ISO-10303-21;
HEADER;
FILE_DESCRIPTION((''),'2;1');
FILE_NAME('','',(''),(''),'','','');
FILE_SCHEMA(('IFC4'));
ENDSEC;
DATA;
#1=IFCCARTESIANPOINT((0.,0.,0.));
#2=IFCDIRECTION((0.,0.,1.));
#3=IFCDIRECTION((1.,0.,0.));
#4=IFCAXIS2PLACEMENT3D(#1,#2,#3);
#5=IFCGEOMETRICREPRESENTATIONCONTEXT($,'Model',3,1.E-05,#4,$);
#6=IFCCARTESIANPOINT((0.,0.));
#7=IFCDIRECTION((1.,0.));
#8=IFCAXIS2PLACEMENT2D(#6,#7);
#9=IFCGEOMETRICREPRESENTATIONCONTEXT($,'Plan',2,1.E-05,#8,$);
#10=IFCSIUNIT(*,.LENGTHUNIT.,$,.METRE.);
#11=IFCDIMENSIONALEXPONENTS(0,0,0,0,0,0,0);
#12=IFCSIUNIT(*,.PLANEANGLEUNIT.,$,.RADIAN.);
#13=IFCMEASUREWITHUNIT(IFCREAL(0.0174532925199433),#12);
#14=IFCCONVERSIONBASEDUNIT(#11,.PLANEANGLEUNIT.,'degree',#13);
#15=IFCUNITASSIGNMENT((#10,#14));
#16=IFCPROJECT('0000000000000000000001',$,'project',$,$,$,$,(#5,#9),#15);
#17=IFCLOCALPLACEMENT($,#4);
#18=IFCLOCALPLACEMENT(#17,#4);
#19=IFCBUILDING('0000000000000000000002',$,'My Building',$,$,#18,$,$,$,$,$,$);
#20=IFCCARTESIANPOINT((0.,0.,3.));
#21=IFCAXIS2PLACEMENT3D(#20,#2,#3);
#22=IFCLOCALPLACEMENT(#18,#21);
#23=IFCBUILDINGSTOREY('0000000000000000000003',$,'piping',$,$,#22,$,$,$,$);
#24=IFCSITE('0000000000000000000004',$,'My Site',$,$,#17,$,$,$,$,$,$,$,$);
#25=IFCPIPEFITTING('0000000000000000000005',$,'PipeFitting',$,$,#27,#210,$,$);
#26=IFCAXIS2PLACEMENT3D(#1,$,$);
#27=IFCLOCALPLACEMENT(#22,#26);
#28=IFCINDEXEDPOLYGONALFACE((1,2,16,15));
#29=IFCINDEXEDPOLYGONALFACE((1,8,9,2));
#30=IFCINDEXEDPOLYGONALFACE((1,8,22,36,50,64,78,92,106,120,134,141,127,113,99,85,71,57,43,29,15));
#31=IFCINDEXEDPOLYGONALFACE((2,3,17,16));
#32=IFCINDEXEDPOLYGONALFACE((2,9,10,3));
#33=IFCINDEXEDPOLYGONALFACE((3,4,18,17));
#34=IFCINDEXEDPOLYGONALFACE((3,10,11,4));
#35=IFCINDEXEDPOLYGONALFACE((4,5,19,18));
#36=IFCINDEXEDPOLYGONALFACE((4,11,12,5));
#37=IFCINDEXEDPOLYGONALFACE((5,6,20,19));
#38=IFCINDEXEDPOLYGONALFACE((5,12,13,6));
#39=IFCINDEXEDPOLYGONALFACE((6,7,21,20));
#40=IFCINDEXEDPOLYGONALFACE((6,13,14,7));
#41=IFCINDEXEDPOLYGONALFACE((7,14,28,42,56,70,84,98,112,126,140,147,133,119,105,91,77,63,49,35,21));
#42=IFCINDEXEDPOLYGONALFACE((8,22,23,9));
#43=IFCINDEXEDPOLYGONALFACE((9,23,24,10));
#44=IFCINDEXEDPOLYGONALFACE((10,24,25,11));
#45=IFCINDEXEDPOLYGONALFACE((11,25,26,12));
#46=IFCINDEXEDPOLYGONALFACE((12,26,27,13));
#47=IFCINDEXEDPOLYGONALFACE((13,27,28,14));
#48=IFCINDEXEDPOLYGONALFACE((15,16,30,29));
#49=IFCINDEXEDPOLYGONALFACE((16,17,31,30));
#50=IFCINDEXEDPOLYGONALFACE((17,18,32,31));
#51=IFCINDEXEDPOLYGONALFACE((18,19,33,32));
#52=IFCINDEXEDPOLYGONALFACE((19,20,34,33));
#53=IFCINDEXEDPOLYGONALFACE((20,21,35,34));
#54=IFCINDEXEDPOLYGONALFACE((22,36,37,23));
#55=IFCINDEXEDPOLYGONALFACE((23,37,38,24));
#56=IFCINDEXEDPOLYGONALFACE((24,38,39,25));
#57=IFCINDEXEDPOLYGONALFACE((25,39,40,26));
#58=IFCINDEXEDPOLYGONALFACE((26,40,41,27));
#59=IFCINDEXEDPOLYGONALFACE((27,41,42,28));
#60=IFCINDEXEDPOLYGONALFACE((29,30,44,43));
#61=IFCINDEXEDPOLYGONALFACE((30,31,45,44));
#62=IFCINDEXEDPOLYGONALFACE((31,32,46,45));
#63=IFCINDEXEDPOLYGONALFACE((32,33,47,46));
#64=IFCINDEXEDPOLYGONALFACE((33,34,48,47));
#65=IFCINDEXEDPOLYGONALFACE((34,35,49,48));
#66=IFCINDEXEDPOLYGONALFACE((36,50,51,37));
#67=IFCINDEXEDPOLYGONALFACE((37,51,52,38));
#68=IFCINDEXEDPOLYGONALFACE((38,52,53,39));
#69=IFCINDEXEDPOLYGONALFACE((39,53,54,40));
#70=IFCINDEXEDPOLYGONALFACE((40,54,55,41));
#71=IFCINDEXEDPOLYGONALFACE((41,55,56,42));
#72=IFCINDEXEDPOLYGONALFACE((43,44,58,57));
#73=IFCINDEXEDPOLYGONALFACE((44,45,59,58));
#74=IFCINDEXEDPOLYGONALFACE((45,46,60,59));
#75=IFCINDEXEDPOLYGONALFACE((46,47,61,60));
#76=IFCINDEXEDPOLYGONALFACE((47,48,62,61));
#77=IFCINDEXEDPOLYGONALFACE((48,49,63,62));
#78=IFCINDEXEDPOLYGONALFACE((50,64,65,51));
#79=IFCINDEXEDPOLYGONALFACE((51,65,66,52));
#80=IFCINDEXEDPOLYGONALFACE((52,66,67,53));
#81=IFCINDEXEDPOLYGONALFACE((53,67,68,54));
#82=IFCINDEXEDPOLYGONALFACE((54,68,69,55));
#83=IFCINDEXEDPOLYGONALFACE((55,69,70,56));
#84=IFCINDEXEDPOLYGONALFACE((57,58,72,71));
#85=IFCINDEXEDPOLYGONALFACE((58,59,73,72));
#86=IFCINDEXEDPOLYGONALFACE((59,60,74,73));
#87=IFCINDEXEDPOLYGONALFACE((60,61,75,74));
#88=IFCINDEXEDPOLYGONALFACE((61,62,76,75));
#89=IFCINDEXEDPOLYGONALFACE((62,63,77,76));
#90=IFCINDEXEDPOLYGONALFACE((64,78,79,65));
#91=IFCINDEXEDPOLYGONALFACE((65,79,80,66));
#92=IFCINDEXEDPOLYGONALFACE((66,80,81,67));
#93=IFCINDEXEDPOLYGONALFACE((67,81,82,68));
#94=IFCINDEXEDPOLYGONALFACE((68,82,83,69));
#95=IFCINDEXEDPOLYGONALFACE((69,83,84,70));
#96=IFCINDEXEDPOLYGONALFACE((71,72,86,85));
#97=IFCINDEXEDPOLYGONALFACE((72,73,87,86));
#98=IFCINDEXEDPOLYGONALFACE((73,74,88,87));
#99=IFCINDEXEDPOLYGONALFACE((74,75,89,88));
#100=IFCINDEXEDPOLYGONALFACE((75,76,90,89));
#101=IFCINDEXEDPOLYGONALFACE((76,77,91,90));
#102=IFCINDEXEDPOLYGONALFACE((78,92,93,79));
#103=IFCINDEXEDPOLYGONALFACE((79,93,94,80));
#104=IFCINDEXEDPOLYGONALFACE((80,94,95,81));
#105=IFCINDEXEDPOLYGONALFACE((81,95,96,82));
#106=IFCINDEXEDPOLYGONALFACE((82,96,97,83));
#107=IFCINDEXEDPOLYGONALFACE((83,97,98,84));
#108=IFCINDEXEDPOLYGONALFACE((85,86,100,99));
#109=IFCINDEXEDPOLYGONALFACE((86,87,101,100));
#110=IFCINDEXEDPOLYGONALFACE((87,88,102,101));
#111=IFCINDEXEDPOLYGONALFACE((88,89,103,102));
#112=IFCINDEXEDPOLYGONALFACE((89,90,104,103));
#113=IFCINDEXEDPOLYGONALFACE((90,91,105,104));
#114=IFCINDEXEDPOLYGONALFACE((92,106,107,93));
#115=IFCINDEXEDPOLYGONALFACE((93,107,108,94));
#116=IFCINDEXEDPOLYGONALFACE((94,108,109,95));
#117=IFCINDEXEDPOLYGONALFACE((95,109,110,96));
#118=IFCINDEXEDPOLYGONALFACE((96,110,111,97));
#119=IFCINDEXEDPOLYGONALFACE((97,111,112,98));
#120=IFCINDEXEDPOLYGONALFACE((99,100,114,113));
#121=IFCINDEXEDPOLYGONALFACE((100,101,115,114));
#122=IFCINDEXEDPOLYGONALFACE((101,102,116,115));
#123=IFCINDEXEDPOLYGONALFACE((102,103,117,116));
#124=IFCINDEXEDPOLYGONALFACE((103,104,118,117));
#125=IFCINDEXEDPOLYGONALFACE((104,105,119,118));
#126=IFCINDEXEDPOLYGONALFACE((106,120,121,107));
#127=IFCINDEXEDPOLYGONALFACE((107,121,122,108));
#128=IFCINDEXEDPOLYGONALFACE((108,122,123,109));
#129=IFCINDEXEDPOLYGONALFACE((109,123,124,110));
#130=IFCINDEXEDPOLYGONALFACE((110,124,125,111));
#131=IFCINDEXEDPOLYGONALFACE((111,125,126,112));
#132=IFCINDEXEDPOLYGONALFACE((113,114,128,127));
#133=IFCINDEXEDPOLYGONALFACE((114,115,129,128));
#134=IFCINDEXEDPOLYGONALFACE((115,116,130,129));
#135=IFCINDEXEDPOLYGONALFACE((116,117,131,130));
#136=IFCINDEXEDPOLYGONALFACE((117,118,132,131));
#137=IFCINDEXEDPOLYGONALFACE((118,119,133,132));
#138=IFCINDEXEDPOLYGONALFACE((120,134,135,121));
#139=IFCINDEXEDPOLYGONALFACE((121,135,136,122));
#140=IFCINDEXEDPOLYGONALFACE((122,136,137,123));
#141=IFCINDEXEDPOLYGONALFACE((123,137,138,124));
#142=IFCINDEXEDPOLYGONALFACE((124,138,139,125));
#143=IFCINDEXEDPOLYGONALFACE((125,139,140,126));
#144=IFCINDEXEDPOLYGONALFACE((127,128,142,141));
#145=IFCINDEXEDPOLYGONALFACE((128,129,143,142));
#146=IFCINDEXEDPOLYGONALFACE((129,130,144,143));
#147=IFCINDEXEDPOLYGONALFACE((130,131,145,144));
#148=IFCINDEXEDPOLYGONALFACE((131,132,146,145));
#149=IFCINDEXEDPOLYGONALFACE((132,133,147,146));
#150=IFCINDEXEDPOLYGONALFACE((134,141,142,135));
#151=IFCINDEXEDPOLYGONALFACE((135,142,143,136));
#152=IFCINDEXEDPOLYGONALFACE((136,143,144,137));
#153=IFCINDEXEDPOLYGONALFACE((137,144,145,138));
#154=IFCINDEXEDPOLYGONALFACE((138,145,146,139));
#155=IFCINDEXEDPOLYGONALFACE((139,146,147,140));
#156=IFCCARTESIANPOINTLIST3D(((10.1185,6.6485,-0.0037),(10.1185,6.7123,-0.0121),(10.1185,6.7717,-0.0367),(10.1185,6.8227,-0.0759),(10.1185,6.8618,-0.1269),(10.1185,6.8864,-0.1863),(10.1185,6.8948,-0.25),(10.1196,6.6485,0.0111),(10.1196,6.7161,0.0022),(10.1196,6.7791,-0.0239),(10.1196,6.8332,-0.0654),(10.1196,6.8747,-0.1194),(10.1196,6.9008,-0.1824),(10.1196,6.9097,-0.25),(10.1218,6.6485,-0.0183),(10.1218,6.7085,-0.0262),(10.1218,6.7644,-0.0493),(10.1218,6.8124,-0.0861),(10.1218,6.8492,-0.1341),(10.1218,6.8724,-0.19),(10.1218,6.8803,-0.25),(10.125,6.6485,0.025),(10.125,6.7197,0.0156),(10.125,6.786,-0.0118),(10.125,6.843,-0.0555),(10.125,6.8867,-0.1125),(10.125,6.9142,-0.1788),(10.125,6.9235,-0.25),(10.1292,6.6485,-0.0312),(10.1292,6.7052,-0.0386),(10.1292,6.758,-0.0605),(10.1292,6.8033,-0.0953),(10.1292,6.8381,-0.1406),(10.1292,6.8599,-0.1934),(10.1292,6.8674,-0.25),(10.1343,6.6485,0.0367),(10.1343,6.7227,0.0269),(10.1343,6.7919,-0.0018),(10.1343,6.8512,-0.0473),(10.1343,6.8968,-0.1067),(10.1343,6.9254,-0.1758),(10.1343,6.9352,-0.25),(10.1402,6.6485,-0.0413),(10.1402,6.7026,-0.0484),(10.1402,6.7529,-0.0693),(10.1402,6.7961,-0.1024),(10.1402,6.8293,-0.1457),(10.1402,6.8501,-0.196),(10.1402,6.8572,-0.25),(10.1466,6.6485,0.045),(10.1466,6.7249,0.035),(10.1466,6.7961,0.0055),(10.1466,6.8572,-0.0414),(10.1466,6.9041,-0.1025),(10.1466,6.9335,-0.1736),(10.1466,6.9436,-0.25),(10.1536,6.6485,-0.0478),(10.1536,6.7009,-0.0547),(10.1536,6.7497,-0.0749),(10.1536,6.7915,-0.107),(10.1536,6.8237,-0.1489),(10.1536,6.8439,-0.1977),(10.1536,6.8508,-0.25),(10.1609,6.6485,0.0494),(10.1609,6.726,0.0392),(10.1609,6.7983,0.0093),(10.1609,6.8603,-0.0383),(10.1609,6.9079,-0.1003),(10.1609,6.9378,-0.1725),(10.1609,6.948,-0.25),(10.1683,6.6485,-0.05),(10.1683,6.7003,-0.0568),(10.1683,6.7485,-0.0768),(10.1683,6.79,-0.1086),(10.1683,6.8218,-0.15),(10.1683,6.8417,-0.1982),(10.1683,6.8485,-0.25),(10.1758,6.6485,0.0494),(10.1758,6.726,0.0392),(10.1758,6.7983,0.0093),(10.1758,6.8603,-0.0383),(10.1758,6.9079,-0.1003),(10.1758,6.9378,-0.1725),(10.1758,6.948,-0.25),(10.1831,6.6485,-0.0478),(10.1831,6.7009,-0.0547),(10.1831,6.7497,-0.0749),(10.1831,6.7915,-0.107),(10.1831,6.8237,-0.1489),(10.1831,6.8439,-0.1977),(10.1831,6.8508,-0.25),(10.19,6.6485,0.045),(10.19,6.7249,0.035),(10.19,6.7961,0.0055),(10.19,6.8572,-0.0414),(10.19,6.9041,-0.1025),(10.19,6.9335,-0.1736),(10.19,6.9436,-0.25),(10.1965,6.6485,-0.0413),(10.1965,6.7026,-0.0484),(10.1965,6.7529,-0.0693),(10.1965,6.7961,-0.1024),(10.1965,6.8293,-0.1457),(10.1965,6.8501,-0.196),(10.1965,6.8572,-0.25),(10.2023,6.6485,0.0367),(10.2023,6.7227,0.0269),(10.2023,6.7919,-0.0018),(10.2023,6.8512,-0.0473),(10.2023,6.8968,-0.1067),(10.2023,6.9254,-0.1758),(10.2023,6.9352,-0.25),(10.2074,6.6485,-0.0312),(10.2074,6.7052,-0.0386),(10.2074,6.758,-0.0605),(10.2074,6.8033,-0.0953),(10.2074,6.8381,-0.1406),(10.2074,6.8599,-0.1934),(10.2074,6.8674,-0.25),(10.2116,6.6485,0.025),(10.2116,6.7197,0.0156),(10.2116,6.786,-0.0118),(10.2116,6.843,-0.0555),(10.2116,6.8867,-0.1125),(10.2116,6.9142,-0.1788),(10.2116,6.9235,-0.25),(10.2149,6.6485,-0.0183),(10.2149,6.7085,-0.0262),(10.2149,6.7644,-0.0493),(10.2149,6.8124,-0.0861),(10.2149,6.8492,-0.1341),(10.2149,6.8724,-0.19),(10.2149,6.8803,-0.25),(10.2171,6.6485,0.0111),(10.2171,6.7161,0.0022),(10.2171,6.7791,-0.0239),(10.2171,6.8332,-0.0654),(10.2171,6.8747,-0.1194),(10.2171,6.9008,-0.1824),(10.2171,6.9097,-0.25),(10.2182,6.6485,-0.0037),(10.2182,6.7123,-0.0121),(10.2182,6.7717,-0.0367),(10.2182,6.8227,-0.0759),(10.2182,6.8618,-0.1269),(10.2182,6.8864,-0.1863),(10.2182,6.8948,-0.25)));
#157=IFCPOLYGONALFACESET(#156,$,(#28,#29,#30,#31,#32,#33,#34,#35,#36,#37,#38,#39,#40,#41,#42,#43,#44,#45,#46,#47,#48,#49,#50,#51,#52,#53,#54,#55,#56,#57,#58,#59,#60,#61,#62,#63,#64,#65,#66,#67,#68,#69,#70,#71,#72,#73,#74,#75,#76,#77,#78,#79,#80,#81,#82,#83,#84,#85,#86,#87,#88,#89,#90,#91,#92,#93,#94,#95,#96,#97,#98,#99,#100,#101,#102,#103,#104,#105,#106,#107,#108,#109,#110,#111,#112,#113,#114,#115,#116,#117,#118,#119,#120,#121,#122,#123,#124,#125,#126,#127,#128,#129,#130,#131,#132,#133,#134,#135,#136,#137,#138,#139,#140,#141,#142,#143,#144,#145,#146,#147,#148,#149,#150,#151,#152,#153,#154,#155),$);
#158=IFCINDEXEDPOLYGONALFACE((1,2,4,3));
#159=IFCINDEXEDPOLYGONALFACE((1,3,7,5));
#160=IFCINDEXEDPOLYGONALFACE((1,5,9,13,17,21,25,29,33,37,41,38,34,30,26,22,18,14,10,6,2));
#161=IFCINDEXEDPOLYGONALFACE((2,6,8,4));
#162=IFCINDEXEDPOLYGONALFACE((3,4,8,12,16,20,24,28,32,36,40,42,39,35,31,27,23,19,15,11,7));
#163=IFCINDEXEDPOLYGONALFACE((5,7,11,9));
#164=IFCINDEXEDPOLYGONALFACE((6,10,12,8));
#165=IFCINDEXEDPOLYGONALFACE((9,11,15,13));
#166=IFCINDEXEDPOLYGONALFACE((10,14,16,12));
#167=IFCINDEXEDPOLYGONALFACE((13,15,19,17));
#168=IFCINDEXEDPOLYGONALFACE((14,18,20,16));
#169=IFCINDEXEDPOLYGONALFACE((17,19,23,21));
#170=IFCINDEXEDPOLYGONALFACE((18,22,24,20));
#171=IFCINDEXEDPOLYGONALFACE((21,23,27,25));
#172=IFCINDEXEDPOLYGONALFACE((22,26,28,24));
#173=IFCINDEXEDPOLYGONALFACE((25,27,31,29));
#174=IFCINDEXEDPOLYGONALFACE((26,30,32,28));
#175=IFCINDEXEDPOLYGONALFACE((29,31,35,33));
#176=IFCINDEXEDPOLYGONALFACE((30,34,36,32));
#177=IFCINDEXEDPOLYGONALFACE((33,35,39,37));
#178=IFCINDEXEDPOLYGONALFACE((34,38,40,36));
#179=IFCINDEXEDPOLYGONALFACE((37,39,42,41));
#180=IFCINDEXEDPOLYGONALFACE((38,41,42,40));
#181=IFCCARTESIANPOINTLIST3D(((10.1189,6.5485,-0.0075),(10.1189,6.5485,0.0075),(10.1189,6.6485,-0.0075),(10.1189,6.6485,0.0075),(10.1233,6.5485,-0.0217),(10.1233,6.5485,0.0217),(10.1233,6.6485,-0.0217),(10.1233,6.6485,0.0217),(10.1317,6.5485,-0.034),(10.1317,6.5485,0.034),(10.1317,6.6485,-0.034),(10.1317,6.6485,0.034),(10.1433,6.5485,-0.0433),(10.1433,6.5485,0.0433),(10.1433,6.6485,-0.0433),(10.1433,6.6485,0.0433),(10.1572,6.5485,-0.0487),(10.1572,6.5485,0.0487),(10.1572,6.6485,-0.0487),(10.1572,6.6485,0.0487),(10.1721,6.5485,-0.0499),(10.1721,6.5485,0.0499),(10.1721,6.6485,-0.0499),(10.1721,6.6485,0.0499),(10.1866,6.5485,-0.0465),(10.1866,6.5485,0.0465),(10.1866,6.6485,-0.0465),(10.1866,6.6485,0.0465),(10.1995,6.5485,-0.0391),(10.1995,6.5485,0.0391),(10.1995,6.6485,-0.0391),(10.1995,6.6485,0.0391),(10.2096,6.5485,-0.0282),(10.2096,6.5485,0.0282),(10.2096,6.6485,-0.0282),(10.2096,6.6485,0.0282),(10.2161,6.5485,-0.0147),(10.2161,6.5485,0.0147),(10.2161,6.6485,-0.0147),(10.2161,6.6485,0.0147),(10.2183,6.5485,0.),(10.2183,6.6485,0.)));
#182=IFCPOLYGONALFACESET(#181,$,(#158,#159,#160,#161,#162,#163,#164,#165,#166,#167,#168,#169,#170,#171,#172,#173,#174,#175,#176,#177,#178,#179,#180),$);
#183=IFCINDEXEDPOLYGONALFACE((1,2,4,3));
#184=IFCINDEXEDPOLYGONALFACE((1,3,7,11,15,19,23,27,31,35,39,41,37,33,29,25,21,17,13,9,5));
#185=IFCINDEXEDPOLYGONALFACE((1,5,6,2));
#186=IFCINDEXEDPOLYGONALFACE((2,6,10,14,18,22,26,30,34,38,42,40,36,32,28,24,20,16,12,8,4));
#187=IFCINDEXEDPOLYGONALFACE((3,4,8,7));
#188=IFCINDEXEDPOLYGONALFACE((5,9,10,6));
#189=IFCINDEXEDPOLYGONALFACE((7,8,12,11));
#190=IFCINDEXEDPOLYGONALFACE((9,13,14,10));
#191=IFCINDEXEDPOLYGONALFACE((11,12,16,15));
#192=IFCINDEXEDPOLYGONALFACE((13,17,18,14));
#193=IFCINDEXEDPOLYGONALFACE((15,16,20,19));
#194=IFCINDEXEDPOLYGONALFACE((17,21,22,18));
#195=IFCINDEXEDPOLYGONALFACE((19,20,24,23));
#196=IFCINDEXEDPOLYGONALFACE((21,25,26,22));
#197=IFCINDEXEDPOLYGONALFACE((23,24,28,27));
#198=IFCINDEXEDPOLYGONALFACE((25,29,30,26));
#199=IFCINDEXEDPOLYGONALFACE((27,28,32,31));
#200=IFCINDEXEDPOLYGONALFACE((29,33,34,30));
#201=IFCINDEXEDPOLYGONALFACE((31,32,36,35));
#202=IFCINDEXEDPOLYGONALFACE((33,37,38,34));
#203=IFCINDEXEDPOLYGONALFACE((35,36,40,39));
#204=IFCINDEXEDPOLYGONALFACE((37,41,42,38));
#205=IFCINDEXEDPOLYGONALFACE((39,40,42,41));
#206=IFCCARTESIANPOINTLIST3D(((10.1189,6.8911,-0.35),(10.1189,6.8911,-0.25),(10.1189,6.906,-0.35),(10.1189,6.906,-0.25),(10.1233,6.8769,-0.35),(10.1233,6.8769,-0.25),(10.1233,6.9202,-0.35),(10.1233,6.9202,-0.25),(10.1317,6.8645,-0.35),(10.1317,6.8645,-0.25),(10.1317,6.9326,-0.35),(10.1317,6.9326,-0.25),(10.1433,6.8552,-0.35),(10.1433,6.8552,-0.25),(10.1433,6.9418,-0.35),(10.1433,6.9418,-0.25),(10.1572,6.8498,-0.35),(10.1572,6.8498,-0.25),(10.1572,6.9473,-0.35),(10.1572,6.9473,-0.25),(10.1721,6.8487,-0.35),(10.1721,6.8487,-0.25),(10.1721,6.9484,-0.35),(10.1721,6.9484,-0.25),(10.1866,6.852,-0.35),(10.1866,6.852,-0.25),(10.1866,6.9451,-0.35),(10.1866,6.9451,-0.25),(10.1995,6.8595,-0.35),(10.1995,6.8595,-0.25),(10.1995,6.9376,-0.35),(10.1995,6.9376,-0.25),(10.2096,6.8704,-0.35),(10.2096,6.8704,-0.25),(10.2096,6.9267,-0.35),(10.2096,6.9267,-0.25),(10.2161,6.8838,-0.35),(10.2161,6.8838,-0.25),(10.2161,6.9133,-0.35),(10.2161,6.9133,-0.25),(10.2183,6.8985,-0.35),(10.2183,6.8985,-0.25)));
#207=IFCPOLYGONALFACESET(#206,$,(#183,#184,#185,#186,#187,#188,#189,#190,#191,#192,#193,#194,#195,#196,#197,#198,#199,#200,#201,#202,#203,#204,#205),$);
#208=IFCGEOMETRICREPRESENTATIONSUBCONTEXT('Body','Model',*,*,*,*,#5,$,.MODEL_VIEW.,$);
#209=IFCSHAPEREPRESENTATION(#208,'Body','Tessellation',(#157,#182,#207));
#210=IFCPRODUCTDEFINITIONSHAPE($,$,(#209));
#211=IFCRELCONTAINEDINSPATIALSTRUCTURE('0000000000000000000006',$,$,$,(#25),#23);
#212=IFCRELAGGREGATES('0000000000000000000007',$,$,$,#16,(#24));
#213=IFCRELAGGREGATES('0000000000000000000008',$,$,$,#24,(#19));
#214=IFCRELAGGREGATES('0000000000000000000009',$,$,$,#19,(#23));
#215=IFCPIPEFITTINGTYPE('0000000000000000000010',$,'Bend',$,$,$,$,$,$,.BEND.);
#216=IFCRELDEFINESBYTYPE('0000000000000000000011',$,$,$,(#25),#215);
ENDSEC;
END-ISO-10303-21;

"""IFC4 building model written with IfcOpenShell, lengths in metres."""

from ifc_helpers import new_model, entity, si_unit, converted_unit, frame, origin_with_axes, origin_2d_with_axis, place, context, subcontext, project, spatial, circle, extrude, source, transform, mapped, type_object, type_shapes, element, save


model = new_model("IFC4")

# Units and contexts
model_context = context("Model", 3, precision=1e-05, world=origin_with_axes())
plan_context = context("Plan", 2, precision=1e-05, world=origin_2d_with_axis())
body_context = subcontext(model_context, "Body", "Model", "MODEL_VIEW")
ifc_project = project(units=[si_unit("LENGTHUNIT", "METRE"), converted_unit("PLANEANGLEUNIT", "degree", entity("IfcReal", 0.0174532925199433), si_unit("PLANEANGLEUNIT", "RADIAN"), dimensions=[0, 0, 0, 0, 0, 0, 0])], contexts=[model_context, plan_context])

# Site, building, storey
site_placement = place(None, origin_with_axes())
site = spatial("IfcSite", under=ifc_project, at=site_placement, Name="My Site")
building_placement = place(site_placement, origin_with_axes())
building = spatial("IfcBuilding", under=site, at=building_placement, Name="My Building")
storey_placement = place(building_placement, frame((0.0, 0.0, 3.0), z_axis=(0.0, 0.0, 1.0), x_axis=(1.0, 0.0, 0.0)))
storey = spatial("IfcBuildingStorey", under=building, at=storey_placement, Name="piping")

# Pipe fitting
pipe_fitting_type = type_object("IfcPipeFittingType", Name="Bend", PredefinedType="BEND")
shared_shape = source(origin_with_axes(), body_context, "Body", "SolidModel", [
    entity("IfcSweptDiskSolid", entity("IfcIndexedPolyCurve", entity("IfcCartesianPointList3D", [[0.0, 0.0, -0.1], [0.0, -0.0732, -0.2768], [0.0, -0.25, -0.35]]), [entity("IfcArcIndex", [1, 2, 3])]), 0.05),
    extrude(circle(Radius=0.05), origin_with_axes(), (0.0, 0.0, -1.0), 0.1),
    extrude(circle(Radius=0.05), frame((0.0, -0.25, -0.35), z_axis=(0.0, -1.0, 0.0), x_axis=(1.0, 0.0, 0.0)), (0.0, 0.0, 1.0), 0.1),
])
type_shapes(pipe_fitting_type, [shared_shape])
for number, where, z_axis, x_axis, name in (
    (1, (10.1683, 6.5485, 0.0), (0.0, -1.0, 0.0), (1.0, 0.0, 0.0), "PipeFitting"),
):
    element("IfcPipeFitting", number, at=place(storey_placement, frame(where, z_axis=z_axis, x_axis=x_axis)), inside=storey, type_object=pipe_fitting_type, Name=name, context=body_context, shape_type="MappedRepresentation", body=[
        mapped(shared_shape, transform((0.0, 0.0, 0.0), x_axis=(1.0, 0.0, 0.0), y_axis=(0.0, 1.0, 0.0), z_axis=(0.0, 0.0, 1.0), scale=1.0)),
    ])

save(model, "model.ifc")
